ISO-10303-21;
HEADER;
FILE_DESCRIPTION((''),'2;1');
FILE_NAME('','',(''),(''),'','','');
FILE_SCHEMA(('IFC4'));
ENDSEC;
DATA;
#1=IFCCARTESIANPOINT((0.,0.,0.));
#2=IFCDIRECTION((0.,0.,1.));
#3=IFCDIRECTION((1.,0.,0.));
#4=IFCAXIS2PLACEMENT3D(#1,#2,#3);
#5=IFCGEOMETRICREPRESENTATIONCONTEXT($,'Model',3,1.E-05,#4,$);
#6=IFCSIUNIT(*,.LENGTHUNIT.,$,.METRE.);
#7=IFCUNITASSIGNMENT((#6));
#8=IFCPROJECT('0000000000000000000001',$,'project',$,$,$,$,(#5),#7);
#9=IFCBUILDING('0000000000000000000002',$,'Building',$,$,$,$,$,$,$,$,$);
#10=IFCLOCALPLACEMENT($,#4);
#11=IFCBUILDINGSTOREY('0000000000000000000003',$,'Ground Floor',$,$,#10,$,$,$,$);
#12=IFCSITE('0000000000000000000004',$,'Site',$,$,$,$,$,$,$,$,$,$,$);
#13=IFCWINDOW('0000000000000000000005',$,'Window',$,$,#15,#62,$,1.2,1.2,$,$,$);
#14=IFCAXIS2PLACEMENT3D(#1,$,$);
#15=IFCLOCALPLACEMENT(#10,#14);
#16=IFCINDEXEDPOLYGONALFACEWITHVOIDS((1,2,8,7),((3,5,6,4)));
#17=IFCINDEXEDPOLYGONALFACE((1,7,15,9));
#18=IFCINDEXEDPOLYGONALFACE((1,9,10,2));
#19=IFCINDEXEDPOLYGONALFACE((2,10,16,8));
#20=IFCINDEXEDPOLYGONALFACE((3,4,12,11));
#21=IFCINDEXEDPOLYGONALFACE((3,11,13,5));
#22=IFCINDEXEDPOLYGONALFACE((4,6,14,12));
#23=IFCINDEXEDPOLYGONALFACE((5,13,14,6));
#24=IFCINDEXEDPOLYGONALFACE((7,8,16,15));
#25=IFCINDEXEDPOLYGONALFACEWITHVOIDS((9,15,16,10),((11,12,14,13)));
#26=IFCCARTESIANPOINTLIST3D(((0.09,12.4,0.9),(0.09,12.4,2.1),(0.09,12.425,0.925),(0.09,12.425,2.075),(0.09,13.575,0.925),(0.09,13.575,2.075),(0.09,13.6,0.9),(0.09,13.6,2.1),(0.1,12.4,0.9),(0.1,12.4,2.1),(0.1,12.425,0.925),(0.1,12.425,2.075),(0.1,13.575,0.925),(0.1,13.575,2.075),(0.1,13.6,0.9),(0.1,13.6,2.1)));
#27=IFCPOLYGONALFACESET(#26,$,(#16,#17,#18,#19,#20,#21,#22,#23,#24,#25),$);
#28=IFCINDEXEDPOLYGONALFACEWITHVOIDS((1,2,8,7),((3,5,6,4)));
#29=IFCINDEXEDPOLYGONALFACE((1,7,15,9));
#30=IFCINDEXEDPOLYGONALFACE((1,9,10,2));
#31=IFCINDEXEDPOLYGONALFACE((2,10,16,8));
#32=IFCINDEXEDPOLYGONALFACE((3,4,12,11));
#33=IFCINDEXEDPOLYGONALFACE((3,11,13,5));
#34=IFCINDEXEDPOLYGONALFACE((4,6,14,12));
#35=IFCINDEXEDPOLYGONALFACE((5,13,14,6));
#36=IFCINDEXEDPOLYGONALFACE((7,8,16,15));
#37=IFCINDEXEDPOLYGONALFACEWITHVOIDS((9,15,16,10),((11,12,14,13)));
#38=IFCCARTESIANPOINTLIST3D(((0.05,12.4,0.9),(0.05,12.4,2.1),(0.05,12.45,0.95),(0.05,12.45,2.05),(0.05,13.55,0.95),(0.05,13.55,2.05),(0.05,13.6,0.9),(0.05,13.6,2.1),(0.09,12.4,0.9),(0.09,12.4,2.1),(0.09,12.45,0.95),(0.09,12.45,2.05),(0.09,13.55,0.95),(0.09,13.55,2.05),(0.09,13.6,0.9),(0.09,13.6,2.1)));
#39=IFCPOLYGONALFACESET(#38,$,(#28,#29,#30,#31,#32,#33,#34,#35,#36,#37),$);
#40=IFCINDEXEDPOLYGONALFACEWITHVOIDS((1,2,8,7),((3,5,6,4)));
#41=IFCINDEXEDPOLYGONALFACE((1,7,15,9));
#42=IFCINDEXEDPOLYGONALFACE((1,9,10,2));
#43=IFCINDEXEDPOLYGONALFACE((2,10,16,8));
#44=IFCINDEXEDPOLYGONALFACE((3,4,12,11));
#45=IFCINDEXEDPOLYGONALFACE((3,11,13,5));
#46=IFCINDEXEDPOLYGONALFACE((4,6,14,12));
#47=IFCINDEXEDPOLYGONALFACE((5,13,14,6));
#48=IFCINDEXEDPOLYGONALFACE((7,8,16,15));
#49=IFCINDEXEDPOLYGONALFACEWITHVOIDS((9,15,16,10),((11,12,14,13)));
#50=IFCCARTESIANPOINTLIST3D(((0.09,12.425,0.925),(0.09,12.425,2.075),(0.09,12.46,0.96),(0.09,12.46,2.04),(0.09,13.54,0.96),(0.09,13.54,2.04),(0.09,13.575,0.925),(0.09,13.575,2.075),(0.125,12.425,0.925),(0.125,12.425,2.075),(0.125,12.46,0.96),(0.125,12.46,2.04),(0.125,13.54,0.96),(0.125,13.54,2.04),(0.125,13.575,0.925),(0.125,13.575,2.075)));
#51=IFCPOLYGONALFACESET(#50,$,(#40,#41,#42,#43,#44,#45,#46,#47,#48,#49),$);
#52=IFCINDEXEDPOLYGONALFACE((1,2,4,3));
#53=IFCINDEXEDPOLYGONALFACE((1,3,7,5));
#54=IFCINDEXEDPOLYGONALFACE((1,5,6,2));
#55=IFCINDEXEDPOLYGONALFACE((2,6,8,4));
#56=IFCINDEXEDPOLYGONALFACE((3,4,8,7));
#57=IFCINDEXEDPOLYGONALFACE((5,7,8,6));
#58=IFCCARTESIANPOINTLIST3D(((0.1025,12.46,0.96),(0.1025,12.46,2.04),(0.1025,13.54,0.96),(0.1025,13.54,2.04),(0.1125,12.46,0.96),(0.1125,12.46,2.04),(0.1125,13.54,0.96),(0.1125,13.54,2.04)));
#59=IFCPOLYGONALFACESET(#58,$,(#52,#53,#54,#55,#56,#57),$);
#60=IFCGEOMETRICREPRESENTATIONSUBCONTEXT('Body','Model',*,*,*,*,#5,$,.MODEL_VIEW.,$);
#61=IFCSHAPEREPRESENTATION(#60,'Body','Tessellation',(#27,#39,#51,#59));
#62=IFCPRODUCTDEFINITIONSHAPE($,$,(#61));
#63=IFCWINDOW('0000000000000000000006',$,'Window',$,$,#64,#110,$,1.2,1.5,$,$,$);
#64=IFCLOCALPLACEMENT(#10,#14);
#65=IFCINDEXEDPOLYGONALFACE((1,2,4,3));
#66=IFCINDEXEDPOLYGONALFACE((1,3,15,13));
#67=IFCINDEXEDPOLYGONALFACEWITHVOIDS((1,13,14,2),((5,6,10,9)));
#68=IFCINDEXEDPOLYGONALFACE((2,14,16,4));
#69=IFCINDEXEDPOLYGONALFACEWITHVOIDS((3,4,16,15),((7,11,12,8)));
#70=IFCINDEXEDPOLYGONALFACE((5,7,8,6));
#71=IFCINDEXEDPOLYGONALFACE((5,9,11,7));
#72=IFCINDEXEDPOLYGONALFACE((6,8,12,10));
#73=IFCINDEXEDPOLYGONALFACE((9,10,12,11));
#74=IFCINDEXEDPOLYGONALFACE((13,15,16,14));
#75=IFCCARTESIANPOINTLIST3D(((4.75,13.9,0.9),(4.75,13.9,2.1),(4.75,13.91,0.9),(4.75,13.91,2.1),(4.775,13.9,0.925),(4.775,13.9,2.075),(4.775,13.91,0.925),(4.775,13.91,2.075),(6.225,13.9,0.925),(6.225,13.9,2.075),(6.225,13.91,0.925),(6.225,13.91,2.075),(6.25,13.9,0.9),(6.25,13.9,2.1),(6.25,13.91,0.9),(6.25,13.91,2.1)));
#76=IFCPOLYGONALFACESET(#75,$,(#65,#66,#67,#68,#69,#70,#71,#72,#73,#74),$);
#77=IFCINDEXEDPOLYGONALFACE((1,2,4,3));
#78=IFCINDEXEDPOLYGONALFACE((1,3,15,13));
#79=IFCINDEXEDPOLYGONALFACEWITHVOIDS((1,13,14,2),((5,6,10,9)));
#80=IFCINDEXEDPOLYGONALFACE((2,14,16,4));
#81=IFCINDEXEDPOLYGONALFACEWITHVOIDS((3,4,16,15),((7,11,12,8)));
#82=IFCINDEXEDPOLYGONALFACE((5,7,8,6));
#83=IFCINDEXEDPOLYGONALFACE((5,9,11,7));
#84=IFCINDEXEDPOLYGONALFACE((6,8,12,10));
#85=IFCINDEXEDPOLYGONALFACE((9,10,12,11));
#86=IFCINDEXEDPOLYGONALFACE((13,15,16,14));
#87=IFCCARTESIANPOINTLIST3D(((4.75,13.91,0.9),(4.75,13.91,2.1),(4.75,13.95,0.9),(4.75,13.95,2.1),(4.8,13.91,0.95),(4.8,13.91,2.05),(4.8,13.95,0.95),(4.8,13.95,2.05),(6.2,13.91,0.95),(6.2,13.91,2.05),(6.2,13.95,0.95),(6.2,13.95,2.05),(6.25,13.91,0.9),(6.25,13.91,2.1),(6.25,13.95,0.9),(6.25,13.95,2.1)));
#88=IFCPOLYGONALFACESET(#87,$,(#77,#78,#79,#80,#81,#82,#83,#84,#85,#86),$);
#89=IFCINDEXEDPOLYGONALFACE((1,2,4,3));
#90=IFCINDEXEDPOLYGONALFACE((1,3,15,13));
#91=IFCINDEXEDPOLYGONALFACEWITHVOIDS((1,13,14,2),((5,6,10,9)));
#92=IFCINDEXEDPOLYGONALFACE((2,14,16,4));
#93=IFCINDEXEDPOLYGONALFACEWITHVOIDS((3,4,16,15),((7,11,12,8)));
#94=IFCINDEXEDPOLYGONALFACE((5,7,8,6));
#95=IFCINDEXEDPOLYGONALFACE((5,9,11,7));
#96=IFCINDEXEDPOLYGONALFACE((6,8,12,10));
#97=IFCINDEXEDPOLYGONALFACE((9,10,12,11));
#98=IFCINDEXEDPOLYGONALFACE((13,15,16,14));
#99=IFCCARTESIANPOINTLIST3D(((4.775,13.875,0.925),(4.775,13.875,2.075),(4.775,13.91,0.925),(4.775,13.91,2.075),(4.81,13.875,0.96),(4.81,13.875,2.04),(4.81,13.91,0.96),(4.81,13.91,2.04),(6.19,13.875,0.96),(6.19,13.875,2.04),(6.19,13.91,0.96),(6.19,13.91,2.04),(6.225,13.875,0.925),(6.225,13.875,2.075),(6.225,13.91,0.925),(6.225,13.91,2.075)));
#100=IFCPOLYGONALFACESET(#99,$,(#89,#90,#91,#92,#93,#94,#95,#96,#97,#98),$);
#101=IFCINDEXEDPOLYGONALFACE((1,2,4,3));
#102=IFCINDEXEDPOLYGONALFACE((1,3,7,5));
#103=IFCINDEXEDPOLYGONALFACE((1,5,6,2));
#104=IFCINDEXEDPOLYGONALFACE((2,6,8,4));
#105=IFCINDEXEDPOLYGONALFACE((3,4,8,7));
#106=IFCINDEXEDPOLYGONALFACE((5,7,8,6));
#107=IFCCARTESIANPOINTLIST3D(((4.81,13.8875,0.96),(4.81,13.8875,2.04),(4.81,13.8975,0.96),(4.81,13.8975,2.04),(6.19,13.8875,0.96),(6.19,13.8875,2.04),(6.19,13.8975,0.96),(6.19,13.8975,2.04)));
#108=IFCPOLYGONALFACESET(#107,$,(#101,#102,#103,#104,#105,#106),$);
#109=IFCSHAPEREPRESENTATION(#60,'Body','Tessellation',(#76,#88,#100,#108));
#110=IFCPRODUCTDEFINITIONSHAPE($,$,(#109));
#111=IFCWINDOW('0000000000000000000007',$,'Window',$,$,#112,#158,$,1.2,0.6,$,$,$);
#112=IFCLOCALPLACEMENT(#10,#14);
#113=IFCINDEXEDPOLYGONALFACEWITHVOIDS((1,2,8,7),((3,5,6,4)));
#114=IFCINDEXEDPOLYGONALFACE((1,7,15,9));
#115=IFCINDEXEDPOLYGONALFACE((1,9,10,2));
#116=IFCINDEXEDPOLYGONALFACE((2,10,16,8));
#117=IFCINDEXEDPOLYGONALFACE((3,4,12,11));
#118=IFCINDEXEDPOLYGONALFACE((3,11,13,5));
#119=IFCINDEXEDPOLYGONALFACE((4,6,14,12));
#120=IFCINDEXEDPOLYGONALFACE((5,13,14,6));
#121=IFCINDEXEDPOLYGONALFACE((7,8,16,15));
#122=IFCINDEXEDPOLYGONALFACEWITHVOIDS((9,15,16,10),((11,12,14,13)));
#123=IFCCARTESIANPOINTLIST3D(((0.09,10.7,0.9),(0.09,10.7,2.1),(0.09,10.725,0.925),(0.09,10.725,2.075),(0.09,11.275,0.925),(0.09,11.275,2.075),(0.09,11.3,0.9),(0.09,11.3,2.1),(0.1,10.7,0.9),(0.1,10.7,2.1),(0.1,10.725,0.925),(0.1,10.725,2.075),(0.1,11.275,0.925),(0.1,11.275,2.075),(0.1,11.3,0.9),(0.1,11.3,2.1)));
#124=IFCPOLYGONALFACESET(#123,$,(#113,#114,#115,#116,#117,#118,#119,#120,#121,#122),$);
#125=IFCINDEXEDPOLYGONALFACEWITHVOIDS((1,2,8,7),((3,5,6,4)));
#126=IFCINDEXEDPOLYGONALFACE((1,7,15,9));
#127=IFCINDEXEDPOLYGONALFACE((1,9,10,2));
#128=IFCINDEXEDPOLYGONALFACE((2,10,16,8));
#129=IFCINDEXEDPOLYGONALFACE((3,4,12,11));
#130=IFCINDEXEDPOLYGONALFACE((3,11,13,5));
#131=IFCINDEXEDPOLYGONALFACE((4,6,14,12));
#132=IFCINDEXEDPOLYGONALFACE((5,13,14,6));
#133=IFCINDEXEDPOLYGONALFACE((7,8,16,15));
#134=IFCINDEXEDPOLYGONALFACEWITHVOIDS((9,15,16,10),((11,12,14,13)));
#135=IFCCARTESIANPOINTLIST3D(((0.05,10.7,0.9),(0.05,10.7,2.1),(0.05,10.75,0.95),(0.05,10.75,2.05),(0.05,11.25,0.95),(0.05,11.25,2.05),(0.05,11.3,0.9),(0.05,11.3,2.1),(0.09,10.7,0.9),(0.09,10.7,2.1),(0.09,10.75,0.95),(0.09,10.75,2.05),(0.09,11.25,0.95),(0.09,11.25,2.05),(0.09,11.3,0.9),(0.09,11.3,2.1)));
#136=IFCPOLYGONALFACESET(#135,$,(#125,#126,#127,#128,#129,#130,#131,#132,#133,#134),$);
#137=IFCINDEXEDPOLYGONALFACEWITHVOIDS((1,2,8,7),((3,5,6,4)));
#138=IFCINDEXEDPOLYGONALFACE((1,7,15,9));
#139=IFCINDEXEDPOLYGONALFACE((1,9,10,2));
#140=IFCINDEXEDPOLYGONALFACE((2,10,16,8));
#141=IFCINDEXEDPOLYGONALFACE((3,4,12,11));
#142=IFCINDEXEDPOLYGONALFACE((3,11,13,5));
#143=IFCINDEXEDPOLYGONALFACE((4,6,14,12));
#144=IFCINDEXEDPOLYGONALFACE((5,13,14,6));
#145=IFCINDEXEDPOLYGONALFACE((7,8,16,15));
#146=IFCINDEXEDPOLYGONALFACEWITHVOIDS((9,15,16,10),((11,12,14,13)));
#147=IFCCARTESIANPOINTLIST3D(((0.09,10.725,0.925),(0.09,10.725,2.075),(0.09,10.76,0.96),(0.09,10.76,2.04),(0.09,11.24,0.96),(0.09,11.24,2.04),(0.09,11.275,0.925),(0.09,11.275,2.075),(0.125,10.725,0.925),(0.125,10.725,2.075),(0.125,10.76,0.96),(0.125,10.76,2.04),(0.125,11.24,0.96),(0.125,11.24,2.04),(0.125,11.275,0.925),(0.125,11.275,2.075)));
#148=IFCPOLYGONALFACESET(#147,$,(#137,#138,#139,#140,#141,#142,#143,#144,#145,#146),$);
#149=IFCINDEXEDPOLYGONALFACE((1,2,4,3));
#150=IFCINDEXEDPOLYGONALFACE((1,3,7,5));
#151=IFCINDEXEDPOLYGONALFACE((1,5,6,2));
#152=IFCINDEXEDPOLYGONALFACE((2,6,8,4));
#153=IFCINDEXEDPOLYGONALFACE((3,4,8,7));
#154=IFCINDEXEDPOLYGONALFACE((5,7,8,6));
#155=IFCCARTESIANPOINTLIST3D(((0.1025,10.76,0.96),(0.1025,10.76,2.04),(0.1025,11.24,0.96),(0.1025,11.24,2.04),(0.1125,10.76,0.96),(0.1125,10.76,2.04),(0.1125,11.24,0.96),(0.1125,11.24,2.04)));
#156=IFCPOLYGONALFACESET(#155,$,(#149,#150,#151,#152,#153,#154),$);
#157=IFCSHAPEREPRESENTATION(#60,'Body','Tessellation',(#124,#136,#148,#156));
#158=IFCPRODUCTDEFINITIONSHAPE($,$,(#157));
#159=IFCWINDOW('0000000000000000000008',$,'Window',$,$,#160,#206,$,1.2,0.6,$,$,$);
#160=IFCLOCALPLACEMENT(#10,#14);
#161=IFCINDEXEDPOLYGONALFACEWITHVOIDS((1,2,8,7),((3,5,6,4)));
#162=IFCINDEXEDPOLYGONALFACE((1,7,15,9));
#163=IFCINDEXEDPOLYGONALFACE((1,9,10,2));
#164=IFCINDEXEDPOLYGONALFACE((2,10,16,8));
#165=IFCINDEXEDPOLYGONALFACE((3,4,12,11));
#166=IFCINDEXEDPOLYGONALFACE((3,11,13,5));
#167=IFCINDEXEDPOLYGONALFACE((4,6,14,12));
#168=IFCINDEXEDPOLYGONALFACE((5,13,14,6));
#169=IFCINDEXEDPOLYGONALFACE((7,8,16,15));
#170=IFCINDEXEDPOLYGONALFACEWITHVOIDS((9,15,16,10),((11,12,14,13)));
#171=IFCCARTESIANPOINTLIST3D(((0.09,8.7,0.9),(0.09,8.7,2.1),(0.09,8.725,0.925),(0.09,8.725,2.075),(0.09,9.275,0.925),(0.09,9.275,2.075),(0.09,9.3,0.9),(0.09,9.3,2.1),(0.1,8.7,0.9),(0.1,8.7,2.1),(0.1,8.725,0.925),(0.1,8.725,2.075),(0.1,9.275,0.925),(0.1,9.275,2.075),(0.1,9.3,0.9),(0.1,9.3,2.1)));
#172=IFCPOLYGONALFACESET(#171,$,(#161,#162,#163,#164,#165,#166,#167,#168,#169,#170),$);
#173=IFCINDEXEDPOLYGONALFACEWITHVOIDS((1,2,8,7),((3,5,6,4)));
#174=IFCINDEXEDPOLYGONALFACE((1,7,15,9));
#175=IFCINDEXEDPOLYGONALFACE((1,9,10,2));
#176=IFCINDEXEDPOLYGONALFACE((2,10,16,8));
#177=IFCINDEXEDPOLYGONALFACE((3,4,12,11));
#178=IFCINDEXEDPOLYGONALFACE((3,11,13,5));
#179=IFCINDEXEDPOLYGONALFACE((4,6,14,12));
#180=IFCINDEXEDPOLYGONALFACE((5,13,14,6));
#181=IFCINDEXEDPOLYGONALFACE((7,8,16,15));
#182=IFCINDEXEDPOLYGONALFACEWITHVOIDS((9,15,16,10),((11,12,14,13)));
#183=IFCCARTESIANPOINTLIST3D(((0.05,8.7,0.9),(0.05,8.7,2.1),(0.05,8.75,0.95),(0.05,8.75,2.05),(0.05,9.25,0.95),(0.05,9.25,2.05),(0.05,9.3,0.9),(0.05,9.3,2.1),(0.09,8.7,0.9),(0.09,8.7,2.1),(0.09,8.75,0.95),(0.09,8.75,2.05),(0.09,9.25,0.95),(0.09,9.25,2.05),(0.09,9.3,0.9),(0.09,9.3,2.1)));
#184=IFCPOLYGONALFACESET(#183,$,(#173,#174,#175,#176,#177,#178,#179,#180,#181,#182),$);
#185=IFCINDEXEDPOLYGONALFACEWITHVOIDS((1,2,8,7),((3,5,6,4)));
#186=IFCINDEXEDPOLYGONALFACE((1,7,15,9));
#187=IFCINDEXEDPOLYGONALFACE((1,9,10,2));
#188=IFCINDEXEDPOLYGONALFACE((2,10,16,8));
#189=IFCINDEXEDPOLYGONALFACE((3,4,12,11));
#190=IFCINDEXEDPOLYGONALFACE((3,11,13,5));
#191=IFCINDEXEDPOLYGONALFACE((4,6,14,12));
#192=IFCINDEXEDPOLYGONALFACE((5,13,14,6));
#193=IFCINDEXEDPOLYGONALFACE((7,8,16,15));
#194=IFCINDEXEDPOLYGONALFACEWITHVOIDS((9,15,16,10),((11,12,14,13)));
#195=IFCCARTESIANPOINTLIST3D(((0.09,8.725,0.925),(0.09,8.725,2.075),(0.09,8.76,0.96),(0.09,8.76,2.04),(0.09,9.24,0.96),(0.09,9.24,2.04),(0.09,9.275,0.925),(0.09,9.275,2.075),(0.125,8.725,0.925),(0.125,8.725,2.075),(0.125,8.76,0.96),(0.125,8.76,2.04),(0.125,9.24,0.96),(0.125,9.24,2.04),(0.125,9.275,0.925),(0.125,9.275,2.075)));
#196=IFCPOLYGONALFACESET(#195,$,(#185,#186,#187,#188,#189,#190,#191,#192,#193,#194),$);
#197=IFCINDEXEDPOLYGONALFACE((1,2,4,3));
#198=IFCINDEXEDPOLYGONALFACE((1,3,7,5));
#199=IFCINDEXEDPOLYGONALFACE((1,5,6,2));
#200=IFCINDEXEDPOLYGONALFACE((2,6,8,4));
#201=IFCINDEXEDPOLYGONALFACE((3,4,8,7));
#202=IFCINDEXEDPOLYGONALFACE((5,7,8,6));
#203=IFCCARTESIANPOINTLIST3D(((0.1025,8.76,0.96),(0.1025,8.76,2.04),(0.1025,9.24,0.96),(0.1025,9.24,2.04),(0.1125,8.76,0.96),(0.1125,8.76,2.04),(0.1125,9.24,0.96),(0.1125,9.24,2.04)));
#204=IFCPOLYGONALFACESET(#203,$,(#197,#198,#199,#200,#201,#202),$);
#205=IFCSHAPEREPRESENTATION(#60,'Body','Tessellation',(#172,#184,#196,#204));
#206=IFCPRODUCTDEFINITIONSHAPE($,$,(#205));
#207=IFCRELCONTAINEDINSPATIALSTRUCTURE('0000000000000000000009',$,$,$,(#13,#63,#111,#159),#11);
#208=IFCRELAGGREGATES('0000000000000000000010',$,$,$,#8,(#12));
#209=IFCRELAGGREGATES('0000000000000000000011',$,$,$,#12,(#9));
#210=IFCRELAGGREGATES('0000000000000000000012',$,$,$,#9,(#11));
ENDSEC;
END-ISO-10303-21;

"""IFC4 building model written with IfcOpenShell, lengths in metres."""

from ifc_helpers import new_model, si_unit, frame, origin_with_axes, place, context, subcontext, project, spatial, line, indexed_curve, outline, extrude, element, save


model = new_model("IFC4")

# Units and contexts
model_context = context("Model", 3, precision=1e-05, world=origin_with_axes())
body_context = subcontext(model_context, "Body", "Model", "MODEL_VIEW")
ifc_project = project(units=[si_unit("LENGTHUNIT", "METRE")], contexts=[model_context])

# Site, building, storey
site = spatial("IfcSite", under=ifc_project, Name="Site")
building = spatial("IfcBuilding", under=site, Name="Building")
storey_placement = place(None, origin_with_axes())
storey = spatial("IfcBuildingStorey", under=building, at=storey_placement, Name="Ground Floor")

# Windows
window_1_placement = place(storey_placement, frame((0.0, 13.6, 0.9), z_axis=(0.0, 0.0, 1.0), x_axis=(0.0, -1.0, 0.0)))
element("IfcWindow", 1, at=window_1_placement, inside=storey, Name="Window", OverallHeight=1.2, OverallWidth=1.2, context=body_context, shape_type="SweptSolid", body=[
    extrude(outline(indexed_curve([(0.0, 0.0), (1.2, 0.0), (1.2, 1.2), (0.0, 1.2)], segments=[line(1, 2, 3, 4, 1)]), holes=[indexed_curve([(0.025, 0.025), (1.175, 0.025), (1.175, 1.175), (0.025, 1.175)], segments=[line(1, 2, 3, 4, 1)])]), frame((0.0, 0.09, 0.0), z_axis=(0.0, -1.0, 0.0), x_axis=(1.0, 0.0, 0.0)), (0.0, 0.0, -1.0), 0.01),
    extrude(outline(indexed_curve([(0.0, 0.0), (1.2, 0.0), (1.2, 1.2), (0.0, 1.2)], segments=[line(1, 2, 3, 4, 1)]), holes=[indexed_curve([(0.05, 0.05), (1.15, 0.05), (1.15, 1.15), (0.05, 1.15)], segments=[line(1, 2, 3, 4, 1)])]), frame((0.0, 0.05, 0.0), z_axis=(0.0, -1.0, 0.0), x_axis=(1.0, 0.0, 0.0)), (0.0, 0.0, -1.0), 0.04),
    extrude(outline(indexed_curve([(0.0, 0.0), (1.15, 0.0), (1.15, 1.15), (0.0, 1.15)], segments=[line(1, 2, 3, 4, 1)]), holes=[indexed_curve([(0.035, 0.035), (1.115, 0.035), (1.115, 1.115), (0.035, 1.115)], segments=[line(1, 2, 3, 4, 1)])]), frame((0.025, 0.09, 0.025), z_axis=(0.0, -1.0, 0.0), x_axis=(1.0, 0.0, 0.0)), (0.0, 0.0, -1.0), 0.035),
    extrude(outline(indexed_curve([(0.035, 0.035), (1.115, 0.035), (1.115, 1.115), (0.035, 1.115)], segments=[line(1, 2, 3, 4, 1)])), frame((0.025, 0.1025, 0.025), z_axis=(0.0, -1.0, 0.0), x_axis=(1.0, 0.0, 0.0)), (0.0, 0.0, -1.0), 0.01),
])
window_2_placement = place(storey_placement, frame((6.25, 14.0, 0.9), z_axis=(0.0, 0.0, 1.0), x_axis=(-1.0, 0.0, 0.0)))
element("IfcWindow", 2, at=window_2_placement, inside=storey, Name="Window", OverallHeight=1.2, OverallWidth=1.5, context=body_context, shape_type="SweptSolid", body=[
    extrude(outline(indexed_curve([(0.0, 0.0), (1.5, 0.0), (1.5, 1.2), (0.0, 1.2)], segments=[line(1, 2, 3, 4, 1)]), holes=[indexed_curve([(0.025, 0.025), (1.475, 0.025), (1.475, 1.175), (0.025, 1.175)], segments=[line(1, 2, 3, 4, 1)])]), frame((0.0, 0.09, 0.0), z_axis=(0.0, -1.0, 0.0), x_axis=(1.0, 0.0, 0.0)), (0.0, 0.0, -1.0), 0.01),
    extrude(outline(indexed_curve([(0.0, 0.0), (1.5, 0.0), (1.5, 1.2), (0.0, 1.2)], segments=[line(1, 2, 3, 4, 1)]), holes=[indexed_curve([(0.05, 0.05), (1.45, 0.05), (1.45, 1.15), (0.05, 1.15)], segments=[line(1, 2, 3, 4, 1)])]), frame((0.0, 0.05, 0.0), z_axis=(0.0, -1.0, 0.0), x_axis=(1.0, 0.0, 0.0)), (0.0, 0.0, -1.0), 0.04),
    extrude(outline(indexed_curve([(0.0, 0.0), (1.45, 0.0), (1.45, 1.15), (0.0, 1.15)], segments=[line(1, 2, 3, 4, 1)]), holes=[indexed_curve([(0.035, 0.035), (1.415, 0.035), (1.415, 1.115), (0.035, 1.115)], segments=[line(1, 2, 3, 4, 1)])]), frame((0.025, 0.09, 0.025), z_axis=(0.0, -1.0, 0.0), x_axis=(1.0, 0.0, 0.0)), (0.0, 0.0, -1.0), 0.035),
    extrude(outline(indexed_curve([(0.035, 0.035), (1.415, 0.035), (1.415, 1.115), (0.035, 1.115)], segments=[line(1, 2, 3, 4, 1)])), frame((0.025, 0.1025, 0.025), z_axis=(0.0, -1.0, 0.0), x_axis=(1.0, 0.0, 0.0)), (0.0, 0.0, -1.0), 0.01),
])
for number, where, z_axis, x_axis, name in (
    (3, (0.0, 11.3, 0.9), (0.0, 0.0, 1.0), (0.0, -1.0, 0.0), "Window"),
    (4, (0.0, 9.3, 0.9), (0.0, 0.0, 1.0), (0.0, -1.0, 0.0), "Window"),
):
    element("IfcWindow", number, at=place(storey_placement, frame(where, z_axis=z_axis, x_axis=x_axis)), inside=storey, Name=name, OverallHeight=1.2, OverallWidth=0.6, context=body_context, shape_type="SweptSolid", body=[
        extrude(outline(indexed_curve([(0.0, 0.0), (0.6, 0.0), (0.6, 1.2), (0.0, 1.2)], segments=[line(1, 2, 3, 4, 1)]), holes=[indexed_curve([(0.025, 0.025), (0.575, 0.025), (0.575, 1.175), (0.025, 1.175)], segments=[line(1, 2, 3, 4, 1)])]), frame((0.0, 0.09, 0.0), z_axis=(0.0, -1.0, 0.0), x_axis=(1.0, 0.0, 0.0)), (0.0, 0.0, -1.0), 0.01),
        extrude(outline(indexed_curve([(0.0, 0.0), (0.6, 0.0), (0.6, 1.2), (0.0, 1.2)], segments=[line(1, 2, 3, 4, 1)]), holes=[indexed_curve([(0.05, 0.05), (0.55, 0.05), (0.55, 1.15), (0.05, 1.15)], segments=[line(1, 2, 3, 4, 1)])]), frame((0.0, 0.05, 0.0), z_axis=(0.0, -1.0, 0.0), x_axis=(1.0, 0.0, 0.0)), (0.0, 0.0, -1.0), 0.04),
        extrude(outline(indexed_curve([(0.0, 0.0), (0.55, 0.0), (0.55, 1.15), (0.0, 1.15)], segments=[line(1, 2, 3, 4, 1)]), holes=[indexed_curve([(0.035, 0.035), (0.515, 0.035), (0.515, 1.115), (0.035, 1.115)], segments=[line(1, 2, 3, 4, 1)])]), frame((0.025, 0.09, 0.025), z_axis=(0.0, -1.0, 0.0), x_axis=(1.0, 0.0, 0.0)), (0.0, 0.0, -1.0), 0.035),
        extrude(outline(indexed_curve([(0.035, 0.035), (0.515, 0.035), (0.515, 1.115), (0.035, 1.115)], segments=[line(1, 2, 3, 4, 1)])), frame((0.025, 0.1025, 0.025), z_axis=(0.0, -1.0, 0.0), x_axis=(1.0, 0.0, 0.0)), (0.0, 0.0, -1.0), 0.01),
    ])

save(model, "model.ifc")
